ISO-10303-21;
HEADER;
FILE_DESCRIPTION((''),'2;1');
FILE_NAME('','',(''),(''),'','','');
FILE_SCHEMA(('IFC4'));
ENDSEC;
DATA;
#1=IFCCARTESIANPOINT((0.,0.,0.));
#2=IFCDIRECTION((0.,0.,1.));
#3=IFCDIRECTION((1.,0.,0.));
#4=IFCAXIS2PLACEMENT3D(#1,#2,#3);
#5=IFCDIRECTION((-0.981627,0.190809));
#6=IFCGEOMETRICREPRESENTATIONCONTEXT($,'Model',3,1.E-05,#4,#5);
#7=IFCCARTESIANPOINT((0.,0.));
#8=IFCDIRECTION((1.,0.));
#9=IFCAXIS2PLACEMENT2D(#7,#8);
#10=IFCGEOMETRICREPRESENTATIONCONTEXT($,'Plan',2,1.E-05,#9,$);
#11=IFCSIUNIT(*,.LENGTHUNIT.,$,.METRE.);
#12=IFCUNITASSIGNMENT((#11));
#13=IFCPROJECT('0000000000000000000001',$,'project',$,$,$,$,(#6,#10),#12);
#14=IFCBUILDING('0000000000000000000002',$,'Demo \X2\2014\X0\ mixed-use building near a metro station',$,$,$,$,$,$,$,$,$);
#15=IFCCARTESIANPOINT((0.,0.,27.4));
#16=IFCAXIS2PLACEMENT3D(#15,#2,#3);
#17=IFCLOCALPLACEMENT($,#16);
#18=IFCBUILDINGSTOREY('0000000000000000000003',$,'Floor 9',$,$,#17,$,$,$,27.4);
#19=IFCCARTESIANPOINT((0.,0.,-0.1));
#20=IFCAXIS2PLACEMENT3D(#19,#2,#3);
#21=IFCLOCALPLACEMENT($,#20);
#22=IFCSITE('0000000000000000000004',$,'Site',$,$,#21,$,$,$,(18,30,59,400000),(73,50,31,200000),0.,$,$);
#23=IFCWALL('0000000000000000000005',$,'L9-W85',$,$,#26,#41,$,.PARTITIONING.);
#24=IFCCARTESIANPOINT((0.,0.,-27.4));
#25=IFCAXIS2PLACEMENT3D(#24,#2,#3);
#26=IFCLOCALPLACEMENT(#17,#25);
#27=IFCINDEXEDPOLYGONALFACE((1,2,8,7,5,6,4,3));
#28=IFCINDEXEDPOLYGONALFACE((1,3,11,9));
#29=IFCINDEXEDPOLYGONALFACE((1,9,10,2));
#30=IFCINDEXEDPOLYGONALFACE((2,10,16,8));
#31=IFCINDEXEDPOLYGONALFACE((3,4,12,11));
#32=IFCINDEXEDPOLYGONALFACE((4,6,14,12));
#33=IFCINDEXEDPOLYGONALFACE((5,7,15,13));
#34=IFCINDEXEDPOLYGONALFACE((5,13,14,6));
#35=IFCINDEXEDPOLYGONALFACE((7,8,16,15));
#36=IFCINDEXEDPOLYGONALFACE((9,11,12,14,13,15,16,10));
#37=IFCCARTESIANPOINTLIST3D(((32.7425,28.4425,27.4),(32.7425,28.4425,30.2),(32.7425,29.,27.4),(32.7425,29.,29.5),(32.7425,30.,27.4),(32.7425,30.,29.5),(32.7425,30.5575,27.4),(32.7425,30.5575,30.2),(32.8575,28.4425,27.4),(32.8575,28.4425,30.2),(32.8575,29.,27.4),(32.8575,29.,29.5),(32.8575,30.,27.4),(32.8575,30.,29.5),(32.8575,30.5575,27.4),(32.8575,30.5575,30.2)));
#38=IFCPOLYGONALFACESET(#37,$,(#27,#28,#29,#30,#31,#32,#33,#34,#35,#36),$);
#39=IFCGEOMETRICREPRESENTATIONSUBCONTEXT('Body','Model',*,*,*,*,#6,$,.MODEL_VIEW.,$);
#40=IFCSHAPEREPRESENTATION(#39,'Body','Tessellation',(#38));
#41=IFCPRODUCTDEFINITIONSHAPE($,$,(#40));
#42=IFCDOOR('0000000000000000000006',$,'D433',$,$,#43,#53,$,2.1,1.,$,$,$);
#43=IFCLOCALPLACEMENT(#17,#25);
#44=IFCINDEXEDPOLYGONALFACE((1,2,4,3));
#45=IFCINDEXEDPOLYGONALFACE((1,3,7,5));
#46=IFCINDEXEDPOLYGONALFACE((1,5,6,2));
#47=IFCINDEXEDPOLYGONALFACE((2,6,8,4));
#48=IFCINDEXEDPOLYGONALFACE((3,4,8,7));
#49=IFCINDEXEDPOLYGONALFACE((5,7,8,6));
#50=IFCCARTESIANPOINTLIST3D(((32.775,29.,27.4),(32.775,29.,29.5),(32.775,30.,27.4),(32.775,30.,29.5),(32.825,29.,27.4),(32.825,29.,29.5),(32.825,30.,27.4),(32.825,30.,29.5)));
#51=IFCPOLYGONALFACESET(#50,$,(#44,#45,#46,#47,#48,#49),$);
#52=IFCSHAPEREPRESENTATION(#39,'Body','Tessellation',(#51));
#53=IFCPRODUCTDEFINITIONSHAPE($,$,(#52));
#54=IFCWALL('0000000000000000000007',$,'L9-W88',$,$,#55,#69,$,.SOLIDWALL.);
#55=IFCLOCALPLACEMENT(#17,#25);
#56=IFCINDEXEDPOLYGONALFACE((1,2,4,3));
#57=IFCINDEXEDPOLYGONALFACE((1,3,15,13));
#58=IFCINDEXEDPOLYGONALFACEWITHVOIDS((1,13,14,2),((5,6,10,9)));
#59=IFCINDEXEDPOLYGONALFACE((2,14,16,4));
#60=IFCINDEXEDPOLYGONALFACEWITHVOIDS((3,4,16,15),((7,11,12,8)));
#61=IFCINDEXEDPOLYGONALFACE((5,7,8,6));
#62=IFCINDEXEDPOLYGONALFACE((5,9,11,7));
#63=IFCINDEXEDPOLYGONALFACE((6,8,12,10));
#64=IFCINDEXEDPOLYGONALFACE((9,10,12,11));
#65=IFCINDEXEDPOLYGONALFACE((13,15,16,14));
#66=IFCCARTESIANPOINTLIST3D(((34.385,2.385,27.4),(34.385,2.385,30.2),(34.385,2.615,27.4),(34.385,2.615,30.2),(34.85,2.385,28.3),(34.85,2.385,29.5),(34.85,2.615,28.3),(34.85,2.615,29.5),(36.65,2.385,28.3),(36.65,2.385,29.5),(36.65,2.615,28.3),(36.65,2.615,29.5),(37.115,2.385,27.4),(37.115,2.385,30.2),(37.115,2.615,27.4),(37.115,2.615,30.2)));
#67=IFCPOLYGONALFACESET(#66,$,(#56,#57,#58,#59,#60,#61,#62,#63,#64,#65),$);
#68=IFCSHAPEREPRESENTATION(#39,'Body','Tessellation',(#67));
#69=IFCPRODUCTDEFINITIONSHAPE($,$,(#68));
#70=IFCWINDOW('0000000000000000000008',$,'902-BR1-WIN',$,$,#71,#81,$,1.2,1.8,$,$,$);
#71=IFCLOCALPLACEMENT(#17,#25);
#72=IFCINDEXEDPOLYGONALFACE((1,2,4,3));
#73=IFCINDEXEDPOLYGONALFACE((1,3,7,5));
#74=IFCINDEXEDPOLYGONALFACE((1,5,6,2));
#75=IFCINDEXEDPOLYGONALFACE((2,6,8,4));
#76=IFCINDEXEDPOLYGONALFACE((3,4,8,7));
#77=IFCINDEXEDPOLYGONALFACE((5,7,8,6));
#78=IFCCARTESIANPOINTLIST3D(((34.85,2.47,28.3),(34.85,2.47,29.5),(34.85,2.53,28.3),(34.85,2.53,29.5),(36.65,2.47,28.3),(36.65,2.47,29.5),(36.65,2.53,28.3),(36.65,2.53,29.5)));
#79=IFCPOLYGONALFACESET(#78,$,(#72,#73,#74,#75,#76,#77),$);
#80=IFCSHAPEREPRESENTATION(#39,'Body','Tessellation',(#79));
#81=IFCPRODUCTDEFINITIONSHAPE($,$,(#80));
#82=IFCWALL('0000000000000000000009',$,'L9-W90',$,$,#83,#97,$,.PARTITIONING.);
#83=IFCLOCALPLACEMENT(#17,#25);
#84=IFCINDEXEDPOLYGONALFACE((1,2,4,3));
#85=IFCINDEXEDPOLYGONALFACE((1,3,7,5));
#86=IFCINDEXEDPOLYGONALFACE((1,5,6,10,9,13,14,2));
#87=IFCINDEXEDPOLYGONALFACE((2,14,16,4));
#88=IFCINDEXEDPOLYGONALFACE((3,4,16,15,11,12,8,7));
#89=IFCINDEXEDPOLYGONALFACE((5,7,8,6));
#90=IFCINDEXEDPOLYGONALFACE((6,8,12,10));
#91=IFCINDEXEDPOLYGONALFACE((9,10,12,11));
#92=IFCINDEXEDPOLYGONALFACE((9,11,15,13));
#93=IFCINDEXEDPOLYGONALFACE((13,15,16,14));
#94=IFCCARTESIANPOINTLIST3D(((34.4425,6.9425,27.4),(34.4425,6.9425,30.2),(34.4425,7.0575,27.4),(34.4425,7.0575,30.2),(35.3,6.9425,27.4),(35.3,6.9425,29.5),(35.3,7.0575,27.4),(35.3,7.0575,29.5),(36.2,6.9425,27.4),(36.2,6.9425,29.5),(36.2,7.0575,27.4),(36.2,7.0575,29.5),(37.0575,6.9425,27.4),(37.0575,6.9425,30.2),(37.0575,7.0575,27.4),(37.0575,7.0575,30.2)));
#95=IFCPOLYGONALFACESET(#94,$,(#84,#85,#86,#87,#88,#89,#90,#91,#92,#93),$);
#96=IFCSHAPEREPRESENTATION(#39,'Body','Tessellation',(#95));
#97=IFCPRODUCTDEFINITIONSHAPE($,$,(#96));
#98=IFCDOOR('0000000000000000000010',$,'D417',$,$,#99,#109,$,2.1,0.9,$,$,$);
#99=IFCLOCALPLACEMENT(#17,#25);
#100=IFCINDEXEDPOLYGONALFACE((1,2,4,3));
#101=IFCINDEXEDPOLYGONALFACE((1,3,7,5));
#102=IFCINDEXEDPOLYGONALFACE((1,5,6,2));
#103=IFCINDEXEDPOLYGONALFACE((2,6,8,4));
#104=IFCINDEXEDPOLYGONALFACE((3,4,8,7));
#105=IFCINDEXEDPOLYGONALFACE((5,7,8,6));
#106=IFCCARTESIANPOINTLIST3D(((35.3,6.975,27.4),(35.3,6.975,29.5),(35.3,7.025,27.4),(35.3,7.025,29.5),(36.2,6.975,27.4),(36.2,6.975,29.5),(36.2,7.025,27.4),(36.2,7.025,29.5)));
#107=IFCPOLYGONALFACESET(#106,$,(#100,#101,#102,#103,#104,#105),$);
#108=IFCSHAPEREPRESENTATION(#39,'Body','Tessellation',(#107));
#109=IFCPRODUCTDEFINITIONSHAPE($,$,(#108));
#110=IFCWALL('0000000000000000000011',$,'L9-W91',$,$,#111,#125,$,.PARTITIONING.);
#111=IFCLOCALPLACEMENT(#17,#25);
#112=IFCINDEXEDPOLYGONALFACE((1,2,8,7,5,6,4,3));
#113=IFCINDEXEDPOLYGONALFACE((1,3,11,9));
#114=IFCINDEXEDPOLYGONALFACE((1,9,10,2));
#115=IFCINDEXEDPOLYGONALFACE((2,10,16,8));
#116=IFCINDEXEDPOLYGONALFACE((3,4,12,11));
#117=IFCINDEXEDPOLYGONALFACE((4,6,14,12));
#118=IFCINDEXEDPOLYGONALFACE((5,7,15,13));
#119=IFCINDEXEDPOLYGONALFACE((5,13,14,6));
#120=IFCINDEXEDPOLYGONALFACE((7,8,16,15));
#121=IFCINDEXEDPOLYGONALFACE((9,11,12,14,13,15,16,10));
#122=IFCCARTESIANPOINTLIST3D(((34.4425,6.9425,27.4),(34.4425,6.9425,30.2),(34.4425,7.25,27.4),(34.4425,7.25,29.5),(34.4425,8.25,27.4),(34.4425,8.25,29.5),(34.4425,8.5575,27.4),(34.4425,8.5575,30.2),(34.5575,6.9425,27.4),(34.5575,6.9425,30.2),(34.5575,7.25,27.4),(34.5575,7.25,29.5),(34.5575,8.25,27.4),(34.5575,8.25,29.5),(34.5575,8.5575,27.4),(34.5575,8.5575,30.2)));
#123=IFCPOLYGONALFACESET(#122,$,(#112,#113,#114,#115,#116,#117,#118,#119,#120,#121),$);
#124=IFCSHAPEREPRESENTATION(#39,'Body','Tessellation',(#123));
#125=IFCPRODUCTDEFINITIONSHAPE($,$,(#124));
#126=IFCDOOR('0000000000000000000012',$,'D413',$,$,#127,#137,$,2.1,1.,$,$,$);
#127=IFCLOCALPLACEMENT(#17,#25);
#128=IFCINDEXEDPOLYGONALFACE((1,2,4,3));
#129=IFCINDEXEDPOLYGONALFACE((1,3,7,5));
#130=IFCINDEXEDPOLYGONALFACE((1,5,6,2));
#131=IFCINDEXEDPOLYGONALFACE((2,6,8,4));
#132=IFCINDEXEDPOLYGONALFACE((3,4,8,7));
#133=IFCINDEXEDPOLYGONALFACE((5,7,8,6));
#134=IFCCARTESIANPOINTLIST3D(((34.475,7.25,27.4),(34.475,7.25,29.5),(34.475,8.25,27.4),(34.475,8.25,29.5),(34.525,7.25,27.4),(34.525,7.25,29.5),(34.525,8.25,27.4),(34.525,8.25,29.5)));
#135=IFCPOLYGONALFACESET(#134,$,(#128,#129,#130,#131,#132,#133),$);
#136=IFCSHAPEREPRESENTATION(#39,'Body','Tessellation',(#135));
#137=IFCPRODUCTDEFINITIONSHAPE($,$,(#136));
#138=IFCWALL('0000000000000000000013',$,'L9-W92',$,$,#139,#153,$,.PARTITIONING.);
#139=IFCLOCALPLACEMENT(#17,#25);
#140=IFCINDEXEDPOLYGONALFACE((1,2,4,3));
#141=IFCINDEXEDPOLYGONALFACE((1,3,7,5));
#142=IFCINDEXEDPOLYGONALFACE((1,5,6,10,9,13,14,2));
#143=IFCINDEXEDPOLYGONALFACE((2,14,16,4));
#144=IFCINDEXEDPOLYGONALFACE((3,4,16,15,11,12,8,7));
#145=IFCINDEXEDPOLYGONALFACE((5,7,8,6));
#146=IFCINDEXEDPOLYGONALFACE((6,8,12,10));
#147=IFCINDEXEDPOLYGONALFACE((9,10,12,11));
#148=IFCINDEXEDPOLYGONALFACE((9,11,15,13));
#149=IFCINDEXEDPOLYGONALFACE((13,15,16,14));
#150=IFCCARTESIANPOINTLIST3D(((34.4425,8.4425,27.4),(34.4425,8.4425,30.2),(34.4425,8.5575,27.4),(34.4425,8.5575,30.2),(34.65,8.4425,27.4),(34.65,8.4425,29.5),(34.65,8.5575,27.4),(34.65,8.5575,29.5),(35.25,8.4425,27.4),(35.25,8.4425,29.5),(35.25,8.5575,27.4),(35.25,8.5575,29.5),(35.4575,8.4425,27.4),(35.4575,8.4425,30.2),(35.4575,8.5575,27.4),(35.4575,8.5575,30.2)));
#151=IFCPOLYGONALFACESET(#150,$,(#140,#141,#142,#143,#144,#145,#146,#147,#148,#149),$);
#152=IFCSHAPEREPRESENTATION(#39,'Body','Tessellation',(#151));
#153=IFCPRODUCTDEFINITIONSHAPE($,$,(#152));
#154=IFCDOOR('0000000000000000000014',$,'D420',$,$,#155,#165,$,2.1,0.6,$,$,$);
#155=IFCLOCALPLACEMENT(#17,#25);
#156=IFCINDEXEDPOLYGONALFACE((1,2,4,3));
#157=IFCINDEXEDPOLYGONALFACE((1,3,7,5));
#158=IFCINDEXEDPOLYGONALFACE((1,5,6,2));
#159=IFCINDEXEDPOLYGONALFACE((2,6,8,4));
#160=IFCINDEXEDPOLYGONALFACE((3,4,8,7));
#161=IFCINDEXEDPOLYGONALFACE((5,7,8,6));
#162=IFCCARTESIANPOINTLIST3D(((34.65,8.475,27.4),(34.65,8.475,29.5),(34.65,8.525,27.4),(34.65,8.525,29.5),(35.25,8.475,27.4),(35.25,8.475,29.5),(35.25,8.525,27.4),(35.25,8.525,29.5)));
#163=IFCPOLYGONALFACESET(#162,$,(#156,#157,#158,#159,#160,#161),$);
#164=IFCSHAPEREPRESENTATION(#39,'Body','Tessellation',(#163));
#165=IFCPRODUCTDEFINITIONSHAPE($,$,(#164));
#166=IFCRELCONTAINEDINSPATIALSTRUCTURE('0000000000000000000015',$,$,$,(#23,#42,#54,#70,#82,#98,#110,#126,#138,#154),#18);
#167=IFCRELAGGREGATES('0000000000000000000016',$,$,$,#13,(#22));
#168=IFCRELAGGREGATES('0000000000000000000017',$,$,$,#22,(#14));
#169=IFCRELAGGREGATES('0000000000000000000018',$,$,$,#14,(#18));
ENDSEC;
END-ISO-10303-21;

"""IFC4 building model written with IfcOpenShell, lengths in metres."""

from ifc_helpers import new_model, si_unit, direction, frame, origin_with_axes, origin_2d_with_axis, place, context, subcontext, project, spatial, line, indexed_curve, outline, extrude, element, fill, save


model = new_model("IFC4")

# Units and contexts
model_context = context("Model", 3, precision=1e-05, world=origin_with_axes(), true_north=direction((-0.981627, 0.190809)))
plan_context = context("Plan", 2, precision=1e-05, world=origin_2d_with_axis())
body_context = subcontext(model_context, "Body", "Model", "MODEL_VIEW")
ifc_project = project(units=[si_unit("LENGTHUNIT", "METRE")], contexts=[model_context, plan_context])

# Site, building, storey
site_placement = place(None, frame((0.0, 0.0, -0.1), z_axis=(0.0, 0.0, 1.0), x_axis=(1.0, 0.0, 0.0)))
site = spatial("IfcSite", under=ifc_project, at=site_placement, Name="Site", RefLatitude=(18, 30, 59, 400000), RefLongitude=(73, 50, 31, 200000), RefElevation=0.0)
building = spatial("IfcBuilding", under=site, Name="Demo — mixed-use building near a metro station")
storey_placement = place(None, frame((0.0, 0.0, 27.4), z_axis=(0.0, 0.0, 1.0), x_axis=(1.0, 0.0, 0.0)))
storey = spatial("IfcBuildingStorey", under=building, at=storey_placement, Name="Floor 9", Elevation=27.4)

# Wall, opening, door
wall_1_placement = place(storey_placement, frame((0.0, 0.0, -27.4), z_axis=(0.0, 0.0, 1.0), x_axis=(1.0, 0.0, 0.0)))
wall_1 = element("IfcWall", 1, at=wall_1_placement, inside=storey, Name="L9-W85", PredefinedType="PARTITIONING", context=body_context, shape_type="SweptSolid", body=[
    extrude(outline(indexed_curve([(32.8575, 30.5575), (32.8575, 28.4425), (32.7425, 28.4425), (32.7425, 30.5575)], segments=[line(1, 2, 3, 4, 1)])), frame((0.0, 0.0, 27.4), z_axis=(0.0, 0.0, 1.0), x_axis=(1.0, 0.0, 0.0)), (0.0, 0.0, 1.0), 2.8),
])
opening_1_placement = place(wall_1_placement, origin_with_axes())
opening_1 = element("IfcOpeningElement", 2, at=opening_1_placement, cuts=wall_1, context=body_context, shape_type="SweptSolid", body=[
    extrude(outline(indexed_curve([(32.9075, 30.0), (32.9075, 29.0), (32.6925, 29.0), (32.6925, 30.0)], segments=[line(1, 2, 3, 4, 1)])), frame((0.0, 0.0, 27.4), z_axis=(0.0, 0.0, 1.0), x_axis=(1.0, 0.0, 0.0)), (0.0, 0.0, 1.0), 2.1),
])
door_1_placement = place(storey_placement, frame((0.0, 0.0, -27.4), z_axis=(0.0, 0.0, 1.0), x_axis=(1.0, 0.0, 0.0)))
door_1 = element("IfcDoor", 3, at=door_1_placement, inside=storey, Name="D433", OverallHeight=2.1, OverallWidth=1.0, context=body_context, shape_type="SweptSolid", body=[
    extrude(outline(indexed_curve([(32.825, 30.0), (32.825, 29.0), (32.775, 29.0), (32.775, 30.0)], segments=[line(1, 2, 3, 4, 1)])), frame((0.0, 0.0, 27.4), z_axis=(0.0, 0.0, 1.0), x_axis=(1.0, 0.0, 0.0)), (0.0, 0.0, 1.0), 2.1),
])
fill(opening_1, door_1)

# Wall, opening, window
wall_2_placement = place(storey_placement, frame((0.0, 0.0, -27.4), z_axis=(0.0, 0.0, 1.0), x_axis=(1.0, 0.0, 0.0)))
wall_2 = element("IfcWall", 4, at=wall_2_placement, inside=storey, Name="L9-W88", PredefinedType="SOLIDWALL", context=body_context, shape_type="SweptSolid", body=[
    extrude(outline(indexed_curve([(34.385, 2.615), (37.115, 2.615), (37.115, 2.385), (34.385, 2.385)], segments=[line(1, 2, 3, 4, 1)])), frame((0.0, 0.0, 27.4), z_axis=(0.0, 0.0, 1.0), x_axis=(1.0, 0.0, 0.0)), (0.0, 0.0, 1.0), 2.8),
])
opening_2_placement = place(wall_2_placement, origin_with_axes())
opening_2 = element("IfcOpeningElement", 5, at=opening_2_placement, cuts=wall_2, context=body_context, shape_type="SweptSolid", body=[
    extrude(outline(indexed_curve([(34.85, 2.665), (36.65, 2.665), (36.65, 2.335), (34.85, 2.335)], segments=[line(1, 2, 3, 4, 1)])), frame((0.0, 0.0, 28.3), z_axis=(0.0, 0.0, 1.0), x_axis=(1.0, 0.0, 0.0)), (0.0, 0.0, 1.0), 1.2),
])
window_placement = place(storey_placement, frame((0.0, 0.0, -27.4), z_axis=(0.0, 0.0, 1.0), x_axis=(1.0, 0.0, 0.0)))
window = element("IfcWindow", 6, at=window_placement, inside=storey, Name="902-BR1-WIN", OverallHeight=1.2, OverallWidth=1.8, context=body_context, shape_type="SweptSolid", body=[
    extrude(outline(indexed_curve([(34.85, 2.53), (36.65, 2.53), (36.65, 2.47), (34.85, 2.47)], segments=[line(1, 2, 3, 4, 1)])), frame((0.0, 0.0, 28.3), z_axis=(0.0, 0.0, 1.0), x_axis=(1.0, 0.0, 0.0)), (0.0, 0.0, 1.0), 1.2),
])
fill(opening_2, window)

# Walls, openings, doors
wall_3_placement = place(storey_placement, frame((0.0, 0.0, -27.4), z_axis=(0.0, 0.0, 1.0), x_axis=(1.0, 0.0, 0.0)))
wall_3 = element("IfcWall", 7, at=wall_3_placement, inside=storey, Name="L9-W90", PredefinedType="PARTITIONING", context=body_context, shape_type="SweptSolid", body=[
    extrude(outline(indexed_curve([(37.0575, 6.9425), (34.4425, 6.9425), (34.4425, 7.0575), (37.0575, 7.0575)], segments=[line(1, 2, 3, 4, 1)])), frame((0.0, 0.0, 27.4), z_axis=(0.0, 0.0, 1.0), x_axis=(1.0, 0.0, 0.0)), (0.0, 0.0, 1.0), 2.8),
])
opening_3_placement = place(wall_3_placement, origin_with_axes())
opening_3 = element("IfcOpeningElement", 8, at=opening_3_placement, cuts=wall_3, context=body_context, shape_type="SweptSolid", body=[
    extrude(outline(indexed_curve([(36.2, 6.8925), (35.3, 6.8925), (35.3, 7.1075), (36.2, 7.1075)], segments=[line(1, 2, 3, 4, 1)])), frame((0.0, 0.0, 27.4), z_axis=(0.0, 0.0, 1.0), x_axis=(1.0, 0.0, 0.0)), (0.0, 0.0, 1.0), 2.1),
])
door_2_placement = place(storey_placement, frame((0.0, 0.0, -27.4), z_axis=(0.0, 0.0, 1.0), x_axis=(1.0, 0.0, 0.0)))
door_2 = element("IfcDoor", 9, at=door_2_placement, inside=storey, Name="D417", OverallHeight=2.1, OverallWidth=0.9, context=body_context, shape_type="SweptSolid", body=[
    extrude(outline(indexed_curve([(36.2, 6.975), (35.3, 6.975), (35.3, 7.025), (36.2, 7.025)], segments=[line(1, 2, 3, 4, 1)])), frame((0.0, 0.0, 27.4), z_axis=(0.0, 0.0, 1.0), x_axis=(1.0, 0.0, 0.0)), (0.0, 0.0, 1.0), 2.1),
])
fill(opening_3, door_2)
wall_4_placement = place(storey_placement, frame((0.0, 0.0, -27.4), z_axis=(0.0, 0.0, 1.0), x_axis=(1.0, 0.0, 0.0)))
wall_4 = element("IfcWall", 10, at=wall_4_placement, inside=storey, Name="L9-W91", PredefinedType="PARTITIONING", context=body_context, shape_type="SweptSolid", body=[
    extrude(outline(indexed_curve([(34.4425, 6.9425), (34.4425, 8.5575), (34.5575, 8.5575), (34.5575, 6.9425)], segments=[line(1, 2, 3, 4, 1)])), frame((0.0, 0.0, 27.4), z_axis=(0.0, 0.0, 1.0), x_axis=(1.0, 0.0, 0.0)), (0.0, 0.0, 1.0), 2.8),
])
opening_4_placement = place(wall_4_placement, origin_with_axes())
opening_4 = element("IfcOpeningElement", 11, at=opening_4_placement, cuts=wall_4, context=body_context, shape_type="SweptSolid", body=[
    extrude(outline(indexed_curve([(34.3925, 7.25), (34.3925, 8.25), (34.6075, 8.25), (34.6075, 7.25)], segments=[line(1, 2, 3, 4, 1)])), frame((0.0, 0.0, 27.4), z_axis=(0.0, 0.0, 1.0), x_axis=(1.0, 0.0, 0.0)), (0.0, 0.0, 1.0), 2.1),
])
door_3_placement = place(storey_placement, frame((0.0, 0.0, -27.4), z_axis=(0.0, 0.0, 1.0), x_axis=(1.0, 0.0, 0.0)))
door_3 = element("IfcDoor", 12, at=door_3_placement, inside=storey, Name="D413", OverallHeight=2.1, OverallWidth=1.0, context=body_context, shape_type="SweptSolid", body=[
    extrude(outline(indexed_curve([(34.475, 7.25), (34.475, 8.25), (34.525, 8.25), (34.525, 7.25)], segments=[line(1, 2, 3, 4, 1)])), frame((0.0, 0.0, 27.4), z_axis=(0.0, 0.0, 1.0), x_axis=(1.0, 0.0, 0.0)), (0.0, 0.0, 1.0), 2.1),
])
fill(opening_4, door_3)
wall_5_placement = place(storey_placement, frame((0.0, 0.0, -27.4), z_axis=(0.0, 0.0, 1.0), x_axis=(1.0, 0.0, 0.0)))
wall_5 = element("IfcWall", 13, at=wall_5_placement, inside=storey, Name="L9-W92", PredefinedType="PARTITIONING", context=body_context, shape_type="SweptSolid", body=[
    extrude(outline(indexed_curve([(35.4575, 8.4425), (34.4425, 8.4425), (34.4425, 8.5575), (35.4575, 8.5575)], segments=[line(1, 2, 3, 4, 1)])), frame((0.0, 0.0, 27.4), z_axis=(0.0, 0.0, 1.0), x_axis=(1.0, 0.0, 0.0)), (0.0, 0.0, 1.0), 2.8),
])
opening_5_placement = place(wall_5_placement, origin_with_axes())
opening_5 = element("IfcOpeningElement", 14, at=opening_5_placement, cuts=wall_5, context=body_context, shape_type="SweptSolid", body=[
    extrude(outline(indexed_curve([(35.25, 8.3925), (34.65, 8.3925), (34.65, 8.6075), (35.25, 8.6075)], segments=[line(1, 2, 3, 4, 1)])), frame((0.0, 0.0, 27.4), z_axis=(0.0, 0.0, 1.0), x_axis=(1.0, 0.0, 0.0)), (0.0, 0.0, 1.0), 2.1),
])
door_4_placement = place(storey_placement, frame((0.0, 0.0, -27.4), z_axis=(0.0, 0.0, 1.0), x_axis=(1.0, 0.0, 0.0)))
door_4 = element("IfcDoor", 15, at=door_4_placement, inside=storey, Name="D420", OverallHeight=2.1, OverallWidth=0.6, context=body_context, shape_type="SweptSolid", body=[
    extrude(outline(indexed_curve([(35.25, 8.475), (34.65, 8.475), (34.65, 8.525), (35.25, 8.525)], segments=[line(1, 2, 3, 4, 1)])), frame((0.0, 0.0, 27.4), z_axis=(0.0, 0.0, 1.0), x_axis=(1.0, 0.0, 0.0)), (0.0, 0.0, 1.0), 2.1),
])
fill(opening_5, door_4)

save(model, "model.ifc")
